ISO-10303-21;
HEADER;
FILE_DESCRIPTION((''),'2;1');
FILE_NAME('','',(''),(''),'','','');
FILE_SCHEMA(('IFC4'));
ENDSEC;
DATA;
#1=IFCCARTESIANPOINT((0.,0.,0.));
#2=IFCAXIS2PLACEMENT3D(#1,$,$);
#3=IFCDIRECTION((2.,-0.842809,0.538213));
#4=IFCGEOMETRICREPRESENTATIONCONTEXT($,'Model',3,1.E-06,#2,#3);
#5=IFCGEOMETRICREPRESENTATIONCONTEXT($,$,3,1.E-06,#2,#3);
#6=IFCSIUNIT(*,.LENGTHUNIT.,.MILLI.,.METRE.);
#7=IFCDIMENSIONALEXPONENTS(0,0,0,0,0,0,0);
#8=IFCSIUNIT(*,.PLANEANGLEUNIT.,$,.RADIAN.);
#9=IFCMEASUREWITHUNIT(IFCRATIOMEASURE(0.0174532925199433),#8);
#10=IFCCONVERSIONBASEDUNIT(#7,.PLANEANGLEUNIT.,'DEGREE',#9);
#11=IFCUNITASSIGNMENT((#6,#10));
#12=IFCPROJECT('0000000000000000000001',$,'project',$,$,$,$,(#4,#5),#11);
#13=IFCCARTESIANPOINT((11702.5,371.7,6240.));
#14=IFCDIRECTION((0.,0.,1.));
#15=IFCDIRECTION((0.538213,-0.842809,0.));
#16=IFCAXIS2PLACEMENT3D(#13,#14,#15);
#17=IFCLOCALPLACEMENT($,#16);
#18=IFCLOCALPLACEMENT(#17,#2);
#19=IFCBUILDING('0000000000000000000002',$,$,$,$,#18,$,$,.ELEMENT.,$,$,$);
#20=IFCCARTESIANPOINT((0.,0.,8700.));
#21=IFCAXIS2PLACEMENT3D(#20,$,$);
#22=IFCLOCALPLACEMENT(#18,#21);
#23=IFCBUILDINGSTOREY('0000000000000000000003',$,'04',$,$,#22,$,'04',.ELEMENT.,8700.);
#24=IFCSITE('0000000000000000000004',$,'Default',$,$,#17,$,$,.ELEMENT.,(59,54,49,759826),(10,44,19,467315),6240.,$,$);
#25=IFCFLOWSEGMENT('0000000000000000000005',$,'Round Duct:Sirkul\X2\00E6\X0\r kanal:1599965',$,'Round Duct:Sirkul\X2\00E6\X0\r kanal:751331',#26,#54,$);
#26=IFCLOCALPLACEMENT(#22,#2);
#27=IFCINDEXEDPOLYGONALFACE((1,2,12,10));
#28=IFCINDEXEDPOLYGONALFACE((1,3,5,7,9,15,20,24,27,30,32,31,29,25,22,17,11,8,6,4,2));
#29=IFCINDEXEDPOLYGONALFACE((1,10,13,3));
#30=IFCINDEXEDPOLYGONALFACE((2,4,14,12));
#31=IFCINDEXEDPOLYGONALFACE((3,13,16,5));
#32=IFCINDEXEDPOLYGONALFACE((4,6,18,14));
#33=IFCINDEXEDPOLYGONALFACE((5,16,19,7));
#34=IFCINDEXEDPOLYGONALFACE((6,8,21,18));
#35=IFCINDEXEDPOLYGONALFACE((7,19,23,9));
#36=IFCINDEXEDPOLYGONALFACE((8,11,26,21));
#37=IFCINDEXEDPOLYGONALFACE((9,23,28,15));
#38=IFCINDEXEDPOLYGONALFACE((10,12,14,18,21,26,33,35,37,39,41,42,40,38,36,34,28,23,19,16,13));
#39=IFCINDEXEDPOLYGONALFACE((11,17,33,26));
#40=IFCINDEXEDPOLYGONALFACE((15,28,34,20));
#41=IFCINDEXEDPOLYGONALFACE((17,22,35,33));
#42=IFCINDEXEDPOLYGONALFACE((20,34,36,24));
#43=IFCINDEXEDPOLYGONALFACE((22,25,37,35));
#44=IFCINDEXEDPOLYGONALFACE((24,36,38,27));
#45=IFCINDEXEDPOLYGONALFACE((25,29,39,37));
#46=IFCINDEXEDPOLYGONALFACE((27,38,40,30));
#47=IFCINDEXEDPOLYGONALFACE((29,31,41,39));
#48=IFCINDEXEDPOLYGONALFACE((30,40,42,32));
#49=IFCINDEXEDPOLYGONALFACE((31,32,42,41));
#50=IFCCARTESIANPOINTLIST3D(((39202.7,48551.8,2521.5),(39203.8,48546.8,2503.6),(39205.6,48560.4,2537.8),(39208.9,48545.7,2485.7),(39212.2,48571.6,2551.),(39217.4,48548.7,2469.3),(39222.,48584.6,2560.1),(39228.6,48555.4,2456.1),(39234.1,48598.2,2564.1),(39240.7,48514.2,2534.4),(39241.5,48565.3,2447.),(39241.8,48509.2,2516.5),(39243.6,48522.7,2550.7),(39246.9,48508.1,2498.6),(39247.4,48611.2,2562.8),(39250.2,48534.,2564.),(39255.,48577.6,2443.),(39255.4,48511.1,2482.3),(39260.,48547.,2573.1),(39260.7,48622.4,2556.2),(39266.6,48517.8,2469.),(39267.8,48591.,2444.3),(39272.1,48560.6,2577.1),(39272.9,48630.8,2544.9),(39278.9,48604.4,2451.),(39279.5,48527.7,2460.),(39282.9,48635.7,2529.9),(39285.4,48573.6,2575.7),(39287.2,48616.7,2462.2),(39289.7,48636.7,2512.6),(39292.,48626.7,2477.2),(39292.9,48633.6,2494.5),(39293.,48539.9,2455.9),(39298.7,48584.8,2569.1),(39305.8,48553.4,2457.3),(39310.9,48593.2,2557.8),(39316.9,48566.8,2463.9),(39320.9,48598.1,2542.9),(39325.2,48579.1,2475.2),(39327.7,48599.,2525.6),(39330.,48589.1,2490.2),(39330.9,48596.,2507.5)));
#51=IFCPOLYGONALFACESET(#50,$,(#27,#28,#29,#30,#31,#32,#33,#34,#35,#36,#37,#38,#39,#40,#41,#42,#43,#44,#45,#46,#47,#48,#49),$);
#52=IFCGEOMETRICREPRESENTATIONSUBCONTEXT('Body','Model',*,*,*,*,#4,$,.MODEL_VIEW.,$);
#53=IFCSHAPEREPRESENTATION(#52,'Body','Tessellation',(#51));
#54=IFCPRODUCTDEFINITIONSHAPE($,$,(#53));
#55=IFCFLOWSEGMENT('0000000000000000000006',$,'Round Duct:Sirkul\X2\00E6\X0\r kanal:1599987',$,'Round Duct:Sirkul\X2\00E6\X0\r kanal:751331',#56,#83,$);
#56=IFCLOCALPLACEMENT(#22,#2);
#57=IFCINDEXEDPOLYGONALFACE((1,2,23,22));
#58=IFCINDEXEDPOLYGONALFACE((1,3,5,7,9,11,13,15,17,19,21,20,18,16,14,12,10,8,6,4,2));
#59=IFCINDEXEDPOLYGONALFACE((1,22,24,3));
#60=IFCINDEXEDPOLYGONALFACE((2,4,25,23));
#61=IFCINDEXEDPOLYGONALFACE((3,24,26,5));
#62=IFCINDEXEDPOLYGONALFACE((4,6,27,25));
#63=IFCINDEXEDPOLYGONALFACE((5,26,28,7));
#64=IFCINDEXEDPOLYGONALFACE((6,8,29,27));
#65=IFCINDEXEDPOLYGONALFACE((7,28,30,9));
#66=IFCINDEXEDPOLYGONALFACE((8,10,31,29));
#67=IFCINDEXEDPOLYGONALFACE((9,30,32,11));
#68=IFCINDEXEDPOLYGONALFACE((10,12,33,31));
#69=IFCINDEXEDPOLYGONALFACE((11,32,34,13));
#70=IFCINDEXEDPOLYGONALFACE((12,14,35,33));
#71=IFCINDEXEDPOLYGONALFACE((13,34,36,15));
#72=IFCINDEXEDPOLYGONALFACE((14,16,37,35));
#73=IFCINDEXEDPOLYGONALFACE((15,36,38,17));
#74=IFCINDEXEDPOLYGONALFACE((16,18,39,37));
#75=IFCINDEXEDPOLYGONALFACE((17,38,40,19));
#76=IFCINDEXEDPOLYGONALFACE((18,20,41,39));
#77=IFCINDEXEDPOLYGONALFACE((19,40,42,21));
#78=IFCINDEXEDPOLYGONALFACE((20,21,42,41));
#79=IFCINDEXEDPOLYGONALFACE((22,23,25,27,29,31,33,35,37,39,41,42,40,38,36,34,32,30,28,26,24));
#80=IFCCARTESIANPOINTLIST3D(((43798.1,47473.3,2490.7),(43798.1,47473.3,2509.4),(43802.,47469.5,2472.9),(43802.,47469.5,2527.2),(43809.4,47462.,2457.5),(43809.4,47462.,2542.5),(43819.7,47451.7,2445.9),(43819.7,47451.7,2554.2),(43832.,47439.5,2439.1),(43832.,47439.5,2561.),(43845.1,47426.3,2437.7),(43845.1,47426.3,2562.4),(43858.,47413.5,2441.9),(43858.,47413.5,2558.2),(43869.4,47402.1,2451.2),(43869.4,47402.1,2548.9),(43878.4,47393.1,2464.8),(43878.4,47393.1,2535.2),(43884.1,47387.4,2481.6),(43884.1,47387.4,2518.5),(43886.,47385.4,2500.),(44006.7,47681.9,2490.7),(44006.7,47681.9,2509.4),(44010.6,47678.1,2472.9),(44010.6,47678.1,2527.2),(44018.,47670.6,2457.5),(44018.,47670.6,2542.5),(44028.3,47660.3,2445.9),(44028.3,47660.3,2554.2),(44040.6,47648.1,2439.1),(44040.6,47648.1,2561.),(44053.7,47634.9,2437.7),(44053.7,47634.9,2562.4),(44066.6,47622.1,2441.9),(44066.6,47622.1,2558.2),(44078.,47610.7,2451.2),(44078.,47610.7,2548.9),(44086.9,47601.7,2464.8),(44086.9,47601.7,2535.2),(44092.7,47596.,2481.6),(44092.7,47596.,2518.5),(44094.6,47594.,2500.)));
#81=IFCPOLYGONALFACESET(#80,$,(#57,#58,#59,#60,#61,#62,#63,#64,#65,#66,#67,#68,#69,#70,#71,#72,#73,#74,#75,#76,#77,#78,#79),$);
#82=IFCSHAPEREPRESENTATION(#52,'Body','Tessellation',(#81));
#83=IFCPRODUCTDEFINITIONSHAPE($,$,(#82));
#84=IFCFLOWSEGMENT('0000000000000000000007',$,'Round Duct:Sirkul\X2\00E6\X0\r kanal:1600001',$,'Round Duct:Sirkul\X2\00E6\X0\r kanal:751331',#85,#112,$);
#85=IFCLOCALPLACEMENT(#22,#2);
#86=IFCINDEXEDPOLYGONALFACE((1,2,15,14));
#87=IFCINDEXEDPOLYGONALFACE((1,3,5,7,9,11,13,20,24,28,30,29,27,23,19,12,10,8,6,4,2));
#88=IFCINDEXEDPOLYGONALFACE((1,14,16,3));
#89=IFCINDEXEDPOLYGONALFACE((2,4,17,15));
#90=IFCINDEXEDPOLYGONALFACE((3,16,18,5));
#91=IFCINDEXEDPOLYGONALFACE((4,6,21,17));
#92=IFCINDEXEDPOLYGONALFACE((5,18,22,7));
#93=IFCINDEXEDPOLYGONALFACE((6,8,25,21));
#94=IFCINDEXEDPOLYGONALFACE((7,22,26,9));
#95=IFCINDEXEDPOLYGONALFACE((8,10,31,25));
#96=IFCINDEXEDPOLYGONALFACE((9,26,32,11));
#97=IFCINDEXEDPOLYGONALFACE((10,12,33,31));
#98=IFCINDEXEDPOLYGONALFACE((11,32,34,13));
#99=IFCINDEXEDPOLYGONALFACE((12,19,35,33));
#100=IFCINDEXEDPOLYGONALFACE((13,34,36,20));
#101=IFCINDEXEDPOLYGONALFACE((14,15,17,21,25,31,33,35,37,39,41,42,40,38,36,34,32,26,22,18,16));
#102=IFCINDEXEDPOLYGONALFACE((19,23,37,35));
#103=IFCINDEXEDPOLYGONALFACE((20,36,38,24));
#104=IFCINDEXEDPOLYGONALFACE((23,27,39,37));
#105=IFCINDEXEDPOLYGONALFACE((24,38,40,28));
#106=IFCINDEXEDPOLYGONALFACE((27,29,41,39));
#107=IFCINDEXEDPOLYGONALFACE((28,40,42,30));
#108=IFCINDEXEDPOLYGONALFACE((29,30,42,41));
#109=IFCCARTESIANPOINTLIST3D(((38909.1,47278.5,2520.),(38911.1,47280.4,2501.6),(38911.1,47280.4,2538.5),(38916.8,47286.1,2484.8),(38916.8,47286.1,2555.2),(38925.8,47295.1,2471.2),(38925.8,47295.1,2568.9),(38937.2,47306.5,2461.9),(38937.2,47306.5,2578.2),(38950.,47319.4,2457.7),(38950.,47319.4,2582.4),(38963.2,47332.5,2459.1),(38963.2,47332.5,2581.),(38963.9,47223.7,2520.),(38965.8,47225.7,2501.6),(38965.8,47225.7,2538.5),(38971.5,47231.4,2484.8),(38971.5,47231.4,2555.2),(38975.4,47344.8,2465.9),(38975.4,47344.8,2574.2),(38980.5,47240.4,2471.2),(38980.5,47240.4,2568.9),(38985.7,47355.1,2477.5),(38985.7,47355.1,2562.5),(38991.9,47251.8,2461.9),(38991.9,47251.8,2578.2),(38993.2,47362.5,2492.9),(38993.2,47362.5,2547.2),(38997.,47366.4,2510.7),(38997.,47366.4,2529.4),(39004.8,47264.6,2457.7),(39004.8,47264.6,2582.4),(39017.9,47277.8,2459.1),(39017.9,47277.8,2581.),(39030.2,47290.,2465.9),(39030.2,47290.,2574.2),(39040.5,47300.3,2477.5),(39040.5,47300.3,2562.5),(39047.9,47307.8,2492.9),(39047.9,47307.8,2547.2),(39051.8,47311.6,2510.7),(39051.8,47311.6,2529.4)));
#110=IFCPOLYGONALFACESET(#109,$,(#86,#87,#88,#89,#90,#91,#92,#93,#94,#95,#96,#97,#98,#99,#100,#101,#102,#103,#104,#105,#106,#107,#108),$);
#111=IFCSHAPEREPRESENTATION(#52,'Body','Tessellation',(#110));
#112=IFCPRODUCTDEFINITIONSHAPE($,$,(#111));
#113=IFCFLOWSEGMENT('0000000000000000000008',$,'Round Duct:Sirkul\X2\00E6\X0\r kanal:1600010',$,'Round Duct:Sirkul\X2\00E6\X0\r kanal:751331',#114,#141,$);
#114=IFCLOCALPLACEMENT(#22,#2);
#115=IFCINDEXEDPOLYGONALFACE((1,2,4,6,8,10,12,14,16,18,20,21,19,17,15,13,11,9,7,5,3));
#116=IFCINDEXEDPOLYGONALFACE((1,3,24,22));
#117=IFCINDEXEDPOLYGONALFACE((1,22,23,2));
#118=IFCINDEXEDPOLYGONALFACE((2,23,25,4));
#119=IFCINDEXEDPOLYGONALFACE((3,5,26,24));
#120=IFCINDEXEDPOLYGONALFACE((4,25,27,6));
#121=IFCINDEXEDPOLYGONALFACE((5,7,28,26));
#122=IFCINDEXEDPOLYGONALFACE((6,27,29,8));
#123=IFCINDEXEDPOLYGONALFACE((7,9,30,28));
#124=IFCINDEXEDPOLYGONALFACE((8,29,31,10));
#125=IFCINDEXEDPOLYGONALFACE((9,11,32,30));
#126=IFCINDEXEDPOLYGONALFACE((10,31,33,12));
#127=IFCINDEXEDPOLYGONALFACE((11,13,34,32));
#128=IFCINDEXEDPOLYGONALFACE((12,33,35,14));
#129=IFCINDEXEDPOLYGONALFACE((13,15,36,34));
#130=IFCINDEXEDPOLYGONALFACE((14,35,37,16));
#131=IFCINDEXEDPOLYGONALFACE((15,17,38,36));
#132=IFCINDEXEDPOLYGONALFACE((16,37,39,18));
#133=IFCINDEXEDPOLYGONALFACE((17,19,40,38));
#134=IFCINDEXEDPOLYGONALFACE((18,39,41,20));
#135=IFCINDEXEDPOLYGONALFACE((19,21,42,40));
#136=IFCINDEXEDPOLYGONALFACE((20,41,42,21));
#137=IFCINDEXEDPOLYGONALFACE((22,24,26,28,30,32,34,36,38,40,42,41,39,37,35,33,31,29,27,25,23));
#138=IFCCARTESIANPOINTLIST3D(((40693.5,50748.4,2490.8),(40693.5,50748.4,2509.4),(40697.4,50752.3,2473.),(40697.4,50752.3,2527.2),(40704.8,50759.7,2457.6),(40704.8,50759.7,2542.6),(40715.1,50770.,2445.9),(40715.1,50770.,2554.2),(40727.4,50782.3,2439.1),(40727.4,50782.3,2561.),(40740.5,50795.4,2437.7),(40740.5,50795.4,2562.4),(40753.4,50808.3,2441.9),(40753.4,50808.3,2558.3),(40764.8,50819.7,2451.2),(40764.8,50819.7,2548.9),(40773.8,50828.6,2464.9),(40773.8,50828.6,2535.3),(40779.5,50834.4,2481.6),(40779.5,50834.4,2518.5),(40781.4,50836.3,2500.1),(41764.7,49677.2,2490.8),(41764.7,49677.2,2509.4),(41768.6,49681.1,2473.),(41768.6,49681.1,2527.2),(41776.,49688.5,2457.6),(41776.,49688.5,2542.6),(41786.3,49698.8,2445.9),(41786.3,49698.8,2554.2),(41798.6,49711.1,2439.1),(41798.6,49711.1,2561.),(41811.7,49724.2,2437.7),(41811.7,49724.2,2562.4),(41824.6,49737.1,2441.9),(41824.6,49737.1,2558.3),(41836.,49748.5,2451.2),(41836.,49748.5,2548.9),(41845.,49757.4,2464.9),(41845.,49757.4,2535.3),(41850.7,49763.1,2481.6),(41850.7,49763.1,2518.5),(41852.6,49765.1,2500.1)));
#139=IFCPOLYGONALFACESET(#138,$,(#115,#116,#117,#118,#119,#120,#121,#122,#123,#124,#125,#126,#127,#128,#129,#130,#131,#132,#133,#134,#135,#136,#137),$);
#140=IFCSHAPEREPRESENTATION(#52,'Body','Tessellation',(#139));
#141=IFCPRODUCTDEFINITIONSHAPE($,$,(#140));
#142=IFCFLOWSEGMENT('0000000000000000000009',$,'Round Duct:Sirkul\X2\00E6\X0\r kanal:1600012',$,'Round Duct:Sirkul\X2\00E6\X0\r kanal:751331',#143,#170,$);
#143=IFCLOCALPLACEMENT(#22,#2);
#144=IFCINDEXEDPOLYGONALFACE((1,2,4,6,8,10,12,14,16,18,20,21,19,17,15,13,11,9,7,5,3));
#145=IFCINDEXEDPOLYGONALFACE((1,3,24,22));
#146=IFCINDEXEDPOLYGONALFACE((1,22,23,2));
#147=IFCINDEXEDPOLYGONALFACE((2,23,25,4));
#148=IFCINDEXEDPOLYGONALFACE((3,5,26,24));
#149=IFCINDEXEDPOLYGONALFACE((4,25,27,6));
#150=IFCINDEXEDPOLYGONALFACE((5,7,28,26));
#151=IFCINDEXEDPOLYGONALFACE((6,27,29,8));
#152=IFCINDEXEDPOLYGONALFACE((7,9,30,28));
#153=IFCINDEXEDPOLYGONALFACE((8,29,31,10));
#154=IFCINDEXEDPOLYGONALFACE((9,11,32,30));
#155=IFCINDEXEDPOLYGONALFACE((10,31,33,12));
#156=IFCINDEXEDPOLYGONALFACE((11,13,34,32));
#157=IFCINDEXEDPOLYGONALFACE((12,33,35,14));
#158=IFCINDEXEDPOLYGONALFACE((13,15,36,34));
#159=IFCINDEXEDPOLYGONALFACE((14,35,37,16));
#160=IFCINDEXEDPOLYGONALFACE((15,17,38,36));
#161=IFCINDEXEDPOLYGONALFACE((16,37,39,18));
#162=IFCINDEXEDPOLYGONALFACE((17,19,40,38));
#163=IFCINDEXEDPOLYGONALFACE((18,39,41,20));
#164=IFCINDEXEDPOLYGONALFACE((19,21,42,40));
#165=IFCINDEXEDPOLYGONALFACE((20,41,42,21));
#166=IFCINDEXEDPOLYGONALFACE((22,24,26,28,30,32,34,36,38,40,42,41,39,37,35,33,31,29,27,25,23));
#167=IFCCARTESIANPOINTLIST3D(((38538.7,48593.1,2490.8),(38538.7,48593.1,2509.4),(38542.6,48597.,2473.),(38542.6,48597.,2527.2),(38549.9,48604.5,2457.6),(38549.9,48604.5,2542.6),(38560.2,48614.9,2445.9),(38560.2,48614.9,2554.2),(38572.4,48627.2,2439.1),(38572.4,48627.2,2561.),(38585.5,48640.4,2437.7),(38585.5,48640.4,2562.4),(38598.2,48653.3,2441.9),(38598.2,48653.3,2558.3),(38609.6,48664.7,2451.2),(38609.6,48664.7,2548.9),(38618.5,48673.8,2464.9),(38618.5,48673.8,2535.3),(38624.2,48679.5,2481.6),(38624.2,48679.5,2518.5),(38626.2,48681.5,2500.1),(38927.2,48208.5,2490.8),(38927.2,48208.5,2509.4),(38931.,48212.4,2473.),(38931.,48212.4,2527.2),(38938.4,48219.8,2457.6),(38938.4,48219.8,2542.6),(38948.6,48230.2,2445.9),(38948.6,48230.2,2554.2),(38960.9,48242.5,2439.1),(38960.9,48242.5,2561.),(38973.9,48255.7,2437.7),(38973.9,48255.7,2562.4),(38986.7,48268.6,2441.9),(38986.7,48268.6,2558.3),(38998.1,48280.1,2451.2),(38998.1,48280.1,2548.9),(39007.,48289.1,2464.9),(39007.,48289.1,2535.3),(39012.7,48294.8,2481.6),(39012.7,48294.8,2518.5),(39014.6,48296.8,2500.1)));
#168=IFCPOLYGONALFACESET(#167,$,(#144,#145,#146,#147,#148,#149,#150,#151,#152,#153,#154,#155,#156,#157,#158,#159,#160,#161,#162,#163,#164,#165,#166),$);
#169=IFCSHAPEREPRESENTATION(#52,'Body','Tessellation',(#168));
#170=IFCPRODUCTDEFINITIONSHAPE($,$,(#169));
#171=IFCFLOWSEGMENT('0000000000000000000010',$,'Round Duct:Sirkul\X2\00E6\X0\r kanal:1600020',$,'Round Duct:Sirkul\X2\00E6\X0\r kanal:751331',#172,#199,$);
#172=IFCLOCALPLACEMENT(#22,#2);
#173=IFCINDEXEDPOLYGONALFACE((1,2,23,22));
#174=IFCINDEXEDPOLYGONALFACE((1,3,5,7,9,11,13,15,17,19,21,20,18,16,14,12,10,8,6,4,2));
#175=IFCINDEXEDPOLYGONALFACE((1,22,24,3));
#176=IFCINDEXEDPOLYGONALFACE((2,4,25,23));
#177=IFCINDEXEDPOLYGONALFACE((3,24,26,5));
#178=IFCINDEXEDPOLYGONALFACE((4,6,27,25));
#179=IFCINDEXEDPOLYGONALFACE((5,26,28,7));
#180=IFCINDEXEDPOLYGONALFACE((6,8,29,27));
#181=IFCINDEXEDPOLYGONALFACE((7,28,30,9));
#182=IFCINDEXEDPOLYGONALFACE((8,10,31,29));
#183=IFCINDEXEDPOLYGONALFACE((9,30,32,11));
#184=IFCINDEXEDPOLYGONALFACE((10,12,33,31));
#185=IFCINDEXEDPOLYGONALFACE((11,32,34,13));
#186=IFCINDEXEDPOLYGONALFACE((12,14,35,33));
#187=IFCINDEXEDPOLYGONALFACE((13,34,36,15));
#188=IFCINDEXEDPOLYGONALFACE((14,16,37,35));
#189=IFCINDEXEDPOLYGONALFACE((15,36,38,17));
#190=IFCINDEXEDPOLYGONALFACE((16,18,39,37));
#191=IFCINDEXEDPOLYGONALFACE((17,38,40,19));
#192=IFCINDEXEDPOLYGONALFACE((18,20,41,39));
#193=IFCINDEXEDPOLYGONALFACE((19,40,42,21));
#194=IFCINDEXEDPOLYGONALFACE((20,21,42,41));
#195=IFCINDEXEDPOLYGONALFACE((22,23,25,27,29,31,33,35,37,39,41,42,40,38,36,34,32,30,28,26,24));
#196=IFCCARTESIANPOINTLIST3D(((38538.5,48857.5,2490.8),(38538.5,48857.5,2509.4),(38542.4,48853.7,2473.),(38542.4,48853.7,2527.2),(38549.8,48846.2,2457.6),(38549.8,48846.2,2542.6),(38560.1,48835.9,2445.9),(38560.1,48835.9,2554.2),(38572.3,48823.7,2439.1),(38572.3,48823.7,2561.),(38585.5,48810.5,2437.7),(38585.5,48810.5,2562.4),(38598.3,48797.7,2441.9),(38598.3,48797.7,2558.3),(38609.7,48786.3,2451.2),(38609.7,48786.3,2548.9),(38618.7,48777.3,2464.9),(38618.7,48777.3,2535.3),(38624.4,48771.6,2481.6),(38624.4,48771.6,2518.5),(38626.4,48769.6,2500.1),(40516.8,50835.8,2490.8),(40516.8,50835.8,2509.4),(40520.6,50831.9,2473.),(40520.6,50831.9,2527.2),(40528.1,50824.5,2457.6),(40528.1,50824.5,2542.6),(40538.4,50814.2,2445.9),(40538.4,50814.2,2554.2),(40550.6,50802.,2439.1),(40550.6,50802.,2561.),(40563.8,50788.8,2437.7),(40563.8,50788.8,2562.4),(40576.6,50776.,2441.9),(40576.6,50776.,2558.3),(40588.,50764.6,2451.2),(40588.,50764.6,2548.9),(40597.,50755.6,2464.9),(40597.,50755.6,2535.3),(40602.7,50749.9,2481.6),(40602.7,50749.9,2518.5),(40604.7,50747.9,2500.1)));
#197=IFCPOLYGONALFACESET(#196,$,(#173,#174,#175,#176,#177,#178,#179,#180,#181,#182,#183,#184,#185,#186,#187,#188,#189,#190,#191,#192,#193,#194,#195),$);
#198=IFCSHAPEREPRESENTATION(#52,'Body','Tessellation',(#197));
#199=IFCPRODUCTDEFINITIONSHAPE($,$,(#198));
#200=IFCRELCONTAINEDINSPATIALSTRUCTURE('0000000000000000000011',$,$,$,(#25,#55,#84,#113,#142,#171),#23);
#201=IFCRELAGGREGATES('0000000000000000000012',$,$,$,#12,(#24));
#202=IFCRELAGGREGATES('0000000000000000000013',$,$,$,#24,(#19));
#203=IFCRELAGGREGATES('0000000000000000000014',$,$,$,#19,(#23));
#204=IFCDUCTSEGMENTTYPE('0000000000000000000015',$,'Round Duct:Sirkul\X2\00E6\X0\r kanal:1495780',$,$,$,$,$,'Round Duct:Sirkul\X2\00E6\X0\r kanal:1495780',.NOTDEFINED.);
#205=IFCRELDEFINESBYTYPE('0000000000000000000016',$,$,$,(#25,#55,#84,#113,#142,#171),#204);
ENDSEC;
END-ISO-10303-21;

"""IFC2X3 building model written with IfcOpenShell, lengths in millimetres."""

from ifc_helpers import new_model, entity, si_unit, converted_unit, direction, frame, origin, origin_2d_with_axis, place, context, subcontext, project, spatial, circle, extrude, type_object, element, save


model = new_model("IFC2X3")

# Units and contexts
model_context = context("Model", 3, precision=1e-06, world=origin(), true_north=direction((2.0, -0.842809, 0.538213)))
context_of_model = context(None, 3, precision=1e-06, world=origin(), true_north=direction((2.0, -0.842809, 0.538213)))
body_context = subcontext(model_context, "Body", "Model", "MODEL_VIEW")
ifc_project = project(units=[si_unit("LENGTHUNIT", "METRE", prefix="MILLI"), converted_unit("PLANEANGLEUNIT", "DEGREE", entity("IfcRatioMeasure", 0.0174532925199433), si_unit("PLANEANGLEUNIT", "RADIAN"), dimensions=[0, 0, 0, 0, 0, 0, 0])], contexts=[model_context, context_of_model])

# Site, building, storey
site_placement = place(None, frame((11702.5, 371.7, 6240.0), z_axis=(0.0, 0.0, 1.0), x_axis=(0.538213, -0.842809, 0.0)))
site = spatial("IfcSite", under=ifc_project, at=site_placement, Name="Default", CompositionType="ELEMENT", RefLatitude=(59, 54, 49, 759826), RefLongitude=(10, 44, 19, 467315), RefElevation=6240.0)
building_placement = place(site_placement, origin())
building = spatial("IfcBuilding", under=site, at=building_placement, CompositionType="ELEMENT")
storey_placement = place(building_placement, frame((0.0, 0.0, 8700.0)))
storey = spatial("IfcBuildingStorey", under=building, at=storey_placement, Name="04", LongName="04", CompositionType="ELEMENT", Elevation=8700.0)

# Flow segments
duct_segment_type = type_object("IfcDuctSegmentType", Name="Round Duct:Sirkulær kanal:1495780", ElementType="Round Duct:Sirkulær kanal:1495780", PredefinedType="NOTDEFINED")
flow_segment_1_placement = place(storey_placement, origin())
element("IfcFlowSegment", 1, at=flow_segment_1_placement, inside=storey, type_object=duct_segment_type, Name="Round Duct:Sirkulær kanal:1599965", ObjectType="Round Duct:Sirkulær kanal:751331", context=body_context, shape_type="SweptSolid", body=[
    extrude(circle(Radius=62.5, at=origin_2d_with_axis()), frame((39247.8, 48591.2, 2503.6), z_axis=(0.690552, -0.683835, 0.2356), x_axis=(-0.703643, -0.710554, 0.0)), (0.0, 0.0, 1.0), 55.0),
])
flow_segment_2_placement = place(storey_placement, origin())
element("IfcFlowSegment", 2, at=flow_segment_2_placement, inside=storey, type_object=duct_segment_type, Name="Round Duct:Sirkulær kanal:1599987", ObjectType="Round Duct:Sirkulær kanal:751331", context=body_context, shape_type="SweptSolid", body=[
    extrude(circle(Radius=62.5, at=origin_2d_with_axis()), frame((43841.8, 47429.6, 2500.0), z_axis=(0.707107, 0.707107, 0.0), x_axis=(0.707107, -0.707107, 0.0)), (0.0, 0.0, 1.0), 295.0),
])
flow_segment_3_placement = place(storey_placement, origin())
element("IfcFlowSegment", 3, at=flow_segment_3_placement, inside=storey, type_object=duct_segment_type, Name="Round Duct:Sirkulær kanal:1600001", ObjectType="Round Duct:Sirkulær kanal:751331", context=body_context, shape_type="SweptSolid", body=[
    extrude(circle(Radius=62.5, at=origin_2d_with_axis()), frame((39008.1, 47267.9, 2520.0), z_axis=(-0.707107, 0.707107, 0.0), x_axis=(-0.707107, -0.707107, 0.0)), (0.0, 0.0, 1.0), 77.4),
])
flow_segment_4_placement = place(storey_placement, origin())
element("IfcFlowSegment", 4, at=flow_segment_4_placement, inside=storey, type_object=duct_segment_type, Name="Round Duct:Sirkulær kanal:1600010", ObjectType="Round Duct:Sirkulær kanal:751331", context=body_context, shape_type="SweptSolid", body=[
    extrude(circle(Radius=62.5, at=origin_2d_with_axis()), frame((40737.2, 50792.1, 2500.1), z_axis=(0.707107, -0.707107, 0.0), x_axis=(0.707107, 0.707107, 0.0)), (0.0, 0.0, 1.0), 1514.9),
])
flow_segment_5_placement = place(storey_placement, origin())
element("IfcFlowSegment", 5, at=flow_segment_5_placement, inside=storey, type_object=duct_segment_type, Name="Round Duct:Sirkulær kanal:1600012", ObjectType="Round Duct:Sirkulær kanal:751331", context=body_context, shape_type="SweptSolid", body=[
    extrude(circle(Radius=62.5, at=origin_2d_with_axis()), frame((38970.6, 48252.4, 2500.1), z_axis=(-0.710554, 0.703643, 0.0), x_axis=(0.703643, 0.710554, 0.0)), (0.0, 0.0, 1.0), 546.7),
])
flow_segment_6_placement = place(storey_placement, origin())
element("IfcFlowSegment", 6, at=flow_segment_6_placement, inside=storey, type_object=duct_segment_type, Name="Round Duct:Sirkulær kanal:1600020", ObjectType="Round Duct:Sirkulær kanal:751331", context=body_context, shape_type="SweptSolid", body=[
    extrude(circle(Radius=62.5, at=origin_2d_with_axis()), frame((38582.2, 48813.8, 2500.1), z_axis=(0.707107, 0.707107, 0.0), x_axis=(0.707107, -0.707107, 0.0)), (0.0, 0.0, 1.0), 2797.7),
])

save(model, "model.ifc")
